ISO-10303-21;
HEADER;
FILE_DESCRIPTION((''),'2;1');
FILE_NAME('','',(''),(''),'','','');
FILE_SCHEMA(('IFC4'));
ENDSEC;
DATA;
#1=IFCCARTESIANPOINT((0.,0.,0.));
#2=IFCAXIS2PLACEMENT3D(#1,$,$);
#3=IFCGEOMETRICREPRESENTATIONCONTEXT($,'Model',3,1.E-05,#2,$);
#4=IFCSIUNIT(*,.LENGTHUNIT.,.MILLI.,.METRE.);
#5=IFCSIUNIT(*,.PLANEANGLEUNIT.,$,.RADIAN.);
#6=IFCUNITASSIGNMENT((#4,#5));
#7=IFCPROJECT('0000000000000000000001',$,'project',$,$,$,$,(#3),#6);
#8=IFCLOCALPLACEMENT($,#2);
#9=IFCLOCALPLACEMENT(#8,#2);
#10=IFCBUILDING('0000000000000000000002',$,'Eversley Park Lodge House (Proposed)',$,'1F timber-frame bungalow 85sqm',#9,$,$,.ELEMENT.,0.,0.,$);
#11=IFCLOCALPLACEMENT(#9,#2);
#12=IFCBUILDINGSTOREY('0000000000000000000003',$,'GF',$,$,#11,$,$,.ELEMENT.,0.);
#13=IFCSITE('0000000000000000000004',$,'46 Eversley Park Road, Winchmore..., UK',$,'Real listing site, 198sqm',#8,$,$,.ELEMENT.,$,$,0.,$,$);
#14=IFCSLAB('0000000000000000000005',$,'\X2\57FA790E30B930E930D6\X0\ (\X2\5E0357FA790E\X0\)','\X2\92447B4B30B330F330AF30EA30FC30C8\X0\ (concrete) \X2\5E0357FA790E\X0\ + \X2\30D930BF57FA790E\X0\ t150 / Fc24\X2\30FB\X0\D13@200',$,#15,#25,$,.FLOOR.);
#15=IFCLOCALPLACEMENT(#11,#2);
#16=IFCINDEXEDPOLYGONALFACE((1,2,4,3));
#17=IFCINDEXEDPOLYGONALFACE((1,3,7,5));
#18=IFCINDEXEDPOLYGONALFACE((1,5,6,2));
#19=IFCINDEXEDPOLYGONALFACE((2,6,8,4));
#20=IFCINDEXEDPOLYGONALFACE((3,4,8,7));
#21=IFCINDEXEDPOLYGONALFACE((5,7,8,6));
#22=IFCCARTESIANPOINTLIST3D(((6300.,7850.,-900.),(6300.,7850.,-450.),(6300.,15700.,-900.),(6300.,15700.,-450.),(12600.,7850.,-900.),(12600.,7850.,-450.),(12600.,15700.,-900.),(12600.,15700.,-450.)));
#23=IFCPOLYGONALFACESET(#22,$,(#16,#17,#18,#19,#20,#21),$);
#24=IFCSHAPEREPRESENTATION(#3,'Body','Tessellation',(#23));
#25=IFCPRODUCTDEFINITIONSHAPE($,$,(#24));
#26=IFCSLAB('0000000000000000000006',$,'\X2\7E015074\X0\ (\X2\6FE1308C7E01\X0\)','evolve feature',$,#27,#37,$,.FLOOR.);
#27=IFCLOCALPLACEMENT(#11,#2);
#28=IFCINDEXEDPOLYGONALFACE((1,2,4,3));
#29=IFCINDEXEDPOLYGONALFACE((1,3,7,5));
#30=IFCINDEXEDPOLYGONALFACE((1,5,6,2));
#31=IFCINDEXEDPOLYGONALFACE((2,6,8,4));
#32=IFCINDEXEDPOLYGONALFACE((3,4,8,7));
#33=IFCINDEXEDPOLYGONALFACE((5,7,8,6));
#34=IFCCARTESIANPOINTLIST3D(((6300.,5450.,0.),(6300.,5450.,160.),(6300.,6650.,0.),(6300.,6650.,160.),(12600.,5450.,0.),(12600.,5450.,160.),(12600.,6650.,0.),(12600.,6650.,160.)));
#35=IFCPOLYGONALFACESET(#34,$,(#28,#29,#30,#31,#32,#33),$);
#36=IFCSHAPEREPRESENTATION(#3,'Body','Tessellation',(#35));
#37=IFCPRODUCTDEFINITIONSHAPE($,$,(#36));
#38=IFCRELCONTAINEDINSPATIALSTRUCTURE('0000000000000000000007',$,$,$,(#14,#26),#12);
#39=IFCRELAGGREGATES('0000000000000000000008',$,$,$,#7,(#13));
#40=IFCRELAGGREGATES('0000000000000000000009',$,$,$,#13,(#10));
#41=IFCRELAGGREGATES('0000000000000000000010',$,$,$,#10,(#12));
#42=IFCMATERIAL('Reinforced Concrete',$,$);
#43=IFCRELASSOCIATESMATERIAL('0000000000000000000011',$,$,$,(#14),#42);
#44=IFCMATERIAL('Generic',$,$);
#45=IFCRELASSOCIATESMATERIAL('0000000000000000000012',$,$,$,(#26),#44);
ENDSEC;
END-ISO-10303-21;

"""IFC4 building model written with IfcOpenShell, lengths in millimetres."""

from ifc_helpers import new_model, si_unit, frame, frame_2d, origin, place, context, project, spatial, rectangle, extrude, material, element, save


model = new_model("IFC4")

# Units and contexts
model_context = context("Model", 3, precision=1e-05, world=origin())
ifc_project = project(units=[si_unit("LENGTHUNIT", "METRE", prefix="MILLI"), si_unit("PLANEANGLEUNIT", "RADIAN")], contexts=[model_context])

# Site, building, storey
site_placement = place(None, origin())
site = spatial("IfcSite", under=ifc_project, at=site_placement, Name="46 Eversley Park Road, Winchmore..., UK", ObjectType="Real listing site, 198sqm", CompositionType="ELEMENT", RefElevation=0.0)
building_placement = place(site_placement, origin())
building = spatial("IfcBuilding", under=site, at=building_placement, Name="Eversley Park Lodge House (Proposed)", ObjectType="1F timber-frame bungalow 85sqm", CompositionType="ELEMENT", ElevationOfRefHeight=0.0, ElevationOfTerrain=0.0)
storey_placement = place(building_placement, origin())
storey = spatial("IfcBuildingStorey", under=building, at=storey_placement, Name="GF", CompositionType="ELEMENT", Elevation=0.0)

# Slabs
ifc_material_1 = material(Name="Reinforced Concrete")
slab_1_placement = place(storey_placement, frame((3150.0, 3925.0, -450.0)))
element("IfcSlab", 1, at=slab_1_placement, inside=storey, material=ifc_material_1, Name="基礎スラブ (布基礎)", Description="鉄筋コンクリート (concrete) 布基礎 + ベタ基礎 t150 / Fc24・D13@200", PredefinedType="FLOOR", context=model_context, shape_type="SweptSolid", body=[
    extrude(rectangle(XDim=6300.0, YDim=7850.0, at=frame_2d((3150.0, 3925.0))), frame((3150.0, 3925.0, -450.0)), (0.0, 0.0, 1.0), 450.0),
])
ifc_material_2 = material(Name="Generic")
slab_2_placement = place(storey_placement, frame((3150.0, 2725.0, 0.0)))
element("IfcSlab", 2, at=slab_2_placement, inside=storey, material=ifc_material_2, Name="縁側 (濡れ縁)", Description="evolve feature", PredefinedType="FLOOR", context=model_context, shape_type="SweptSolid", body=[
    extrude(rectangle(XDim=6300.0, YDim=1200.0, at=frame_2d((3150.0, 600.0))), frame((3150.0, 2725.0, 0.0)), (0.0, 0.0, 1.0), 160.0),
])

save(model, "model.ifc")
